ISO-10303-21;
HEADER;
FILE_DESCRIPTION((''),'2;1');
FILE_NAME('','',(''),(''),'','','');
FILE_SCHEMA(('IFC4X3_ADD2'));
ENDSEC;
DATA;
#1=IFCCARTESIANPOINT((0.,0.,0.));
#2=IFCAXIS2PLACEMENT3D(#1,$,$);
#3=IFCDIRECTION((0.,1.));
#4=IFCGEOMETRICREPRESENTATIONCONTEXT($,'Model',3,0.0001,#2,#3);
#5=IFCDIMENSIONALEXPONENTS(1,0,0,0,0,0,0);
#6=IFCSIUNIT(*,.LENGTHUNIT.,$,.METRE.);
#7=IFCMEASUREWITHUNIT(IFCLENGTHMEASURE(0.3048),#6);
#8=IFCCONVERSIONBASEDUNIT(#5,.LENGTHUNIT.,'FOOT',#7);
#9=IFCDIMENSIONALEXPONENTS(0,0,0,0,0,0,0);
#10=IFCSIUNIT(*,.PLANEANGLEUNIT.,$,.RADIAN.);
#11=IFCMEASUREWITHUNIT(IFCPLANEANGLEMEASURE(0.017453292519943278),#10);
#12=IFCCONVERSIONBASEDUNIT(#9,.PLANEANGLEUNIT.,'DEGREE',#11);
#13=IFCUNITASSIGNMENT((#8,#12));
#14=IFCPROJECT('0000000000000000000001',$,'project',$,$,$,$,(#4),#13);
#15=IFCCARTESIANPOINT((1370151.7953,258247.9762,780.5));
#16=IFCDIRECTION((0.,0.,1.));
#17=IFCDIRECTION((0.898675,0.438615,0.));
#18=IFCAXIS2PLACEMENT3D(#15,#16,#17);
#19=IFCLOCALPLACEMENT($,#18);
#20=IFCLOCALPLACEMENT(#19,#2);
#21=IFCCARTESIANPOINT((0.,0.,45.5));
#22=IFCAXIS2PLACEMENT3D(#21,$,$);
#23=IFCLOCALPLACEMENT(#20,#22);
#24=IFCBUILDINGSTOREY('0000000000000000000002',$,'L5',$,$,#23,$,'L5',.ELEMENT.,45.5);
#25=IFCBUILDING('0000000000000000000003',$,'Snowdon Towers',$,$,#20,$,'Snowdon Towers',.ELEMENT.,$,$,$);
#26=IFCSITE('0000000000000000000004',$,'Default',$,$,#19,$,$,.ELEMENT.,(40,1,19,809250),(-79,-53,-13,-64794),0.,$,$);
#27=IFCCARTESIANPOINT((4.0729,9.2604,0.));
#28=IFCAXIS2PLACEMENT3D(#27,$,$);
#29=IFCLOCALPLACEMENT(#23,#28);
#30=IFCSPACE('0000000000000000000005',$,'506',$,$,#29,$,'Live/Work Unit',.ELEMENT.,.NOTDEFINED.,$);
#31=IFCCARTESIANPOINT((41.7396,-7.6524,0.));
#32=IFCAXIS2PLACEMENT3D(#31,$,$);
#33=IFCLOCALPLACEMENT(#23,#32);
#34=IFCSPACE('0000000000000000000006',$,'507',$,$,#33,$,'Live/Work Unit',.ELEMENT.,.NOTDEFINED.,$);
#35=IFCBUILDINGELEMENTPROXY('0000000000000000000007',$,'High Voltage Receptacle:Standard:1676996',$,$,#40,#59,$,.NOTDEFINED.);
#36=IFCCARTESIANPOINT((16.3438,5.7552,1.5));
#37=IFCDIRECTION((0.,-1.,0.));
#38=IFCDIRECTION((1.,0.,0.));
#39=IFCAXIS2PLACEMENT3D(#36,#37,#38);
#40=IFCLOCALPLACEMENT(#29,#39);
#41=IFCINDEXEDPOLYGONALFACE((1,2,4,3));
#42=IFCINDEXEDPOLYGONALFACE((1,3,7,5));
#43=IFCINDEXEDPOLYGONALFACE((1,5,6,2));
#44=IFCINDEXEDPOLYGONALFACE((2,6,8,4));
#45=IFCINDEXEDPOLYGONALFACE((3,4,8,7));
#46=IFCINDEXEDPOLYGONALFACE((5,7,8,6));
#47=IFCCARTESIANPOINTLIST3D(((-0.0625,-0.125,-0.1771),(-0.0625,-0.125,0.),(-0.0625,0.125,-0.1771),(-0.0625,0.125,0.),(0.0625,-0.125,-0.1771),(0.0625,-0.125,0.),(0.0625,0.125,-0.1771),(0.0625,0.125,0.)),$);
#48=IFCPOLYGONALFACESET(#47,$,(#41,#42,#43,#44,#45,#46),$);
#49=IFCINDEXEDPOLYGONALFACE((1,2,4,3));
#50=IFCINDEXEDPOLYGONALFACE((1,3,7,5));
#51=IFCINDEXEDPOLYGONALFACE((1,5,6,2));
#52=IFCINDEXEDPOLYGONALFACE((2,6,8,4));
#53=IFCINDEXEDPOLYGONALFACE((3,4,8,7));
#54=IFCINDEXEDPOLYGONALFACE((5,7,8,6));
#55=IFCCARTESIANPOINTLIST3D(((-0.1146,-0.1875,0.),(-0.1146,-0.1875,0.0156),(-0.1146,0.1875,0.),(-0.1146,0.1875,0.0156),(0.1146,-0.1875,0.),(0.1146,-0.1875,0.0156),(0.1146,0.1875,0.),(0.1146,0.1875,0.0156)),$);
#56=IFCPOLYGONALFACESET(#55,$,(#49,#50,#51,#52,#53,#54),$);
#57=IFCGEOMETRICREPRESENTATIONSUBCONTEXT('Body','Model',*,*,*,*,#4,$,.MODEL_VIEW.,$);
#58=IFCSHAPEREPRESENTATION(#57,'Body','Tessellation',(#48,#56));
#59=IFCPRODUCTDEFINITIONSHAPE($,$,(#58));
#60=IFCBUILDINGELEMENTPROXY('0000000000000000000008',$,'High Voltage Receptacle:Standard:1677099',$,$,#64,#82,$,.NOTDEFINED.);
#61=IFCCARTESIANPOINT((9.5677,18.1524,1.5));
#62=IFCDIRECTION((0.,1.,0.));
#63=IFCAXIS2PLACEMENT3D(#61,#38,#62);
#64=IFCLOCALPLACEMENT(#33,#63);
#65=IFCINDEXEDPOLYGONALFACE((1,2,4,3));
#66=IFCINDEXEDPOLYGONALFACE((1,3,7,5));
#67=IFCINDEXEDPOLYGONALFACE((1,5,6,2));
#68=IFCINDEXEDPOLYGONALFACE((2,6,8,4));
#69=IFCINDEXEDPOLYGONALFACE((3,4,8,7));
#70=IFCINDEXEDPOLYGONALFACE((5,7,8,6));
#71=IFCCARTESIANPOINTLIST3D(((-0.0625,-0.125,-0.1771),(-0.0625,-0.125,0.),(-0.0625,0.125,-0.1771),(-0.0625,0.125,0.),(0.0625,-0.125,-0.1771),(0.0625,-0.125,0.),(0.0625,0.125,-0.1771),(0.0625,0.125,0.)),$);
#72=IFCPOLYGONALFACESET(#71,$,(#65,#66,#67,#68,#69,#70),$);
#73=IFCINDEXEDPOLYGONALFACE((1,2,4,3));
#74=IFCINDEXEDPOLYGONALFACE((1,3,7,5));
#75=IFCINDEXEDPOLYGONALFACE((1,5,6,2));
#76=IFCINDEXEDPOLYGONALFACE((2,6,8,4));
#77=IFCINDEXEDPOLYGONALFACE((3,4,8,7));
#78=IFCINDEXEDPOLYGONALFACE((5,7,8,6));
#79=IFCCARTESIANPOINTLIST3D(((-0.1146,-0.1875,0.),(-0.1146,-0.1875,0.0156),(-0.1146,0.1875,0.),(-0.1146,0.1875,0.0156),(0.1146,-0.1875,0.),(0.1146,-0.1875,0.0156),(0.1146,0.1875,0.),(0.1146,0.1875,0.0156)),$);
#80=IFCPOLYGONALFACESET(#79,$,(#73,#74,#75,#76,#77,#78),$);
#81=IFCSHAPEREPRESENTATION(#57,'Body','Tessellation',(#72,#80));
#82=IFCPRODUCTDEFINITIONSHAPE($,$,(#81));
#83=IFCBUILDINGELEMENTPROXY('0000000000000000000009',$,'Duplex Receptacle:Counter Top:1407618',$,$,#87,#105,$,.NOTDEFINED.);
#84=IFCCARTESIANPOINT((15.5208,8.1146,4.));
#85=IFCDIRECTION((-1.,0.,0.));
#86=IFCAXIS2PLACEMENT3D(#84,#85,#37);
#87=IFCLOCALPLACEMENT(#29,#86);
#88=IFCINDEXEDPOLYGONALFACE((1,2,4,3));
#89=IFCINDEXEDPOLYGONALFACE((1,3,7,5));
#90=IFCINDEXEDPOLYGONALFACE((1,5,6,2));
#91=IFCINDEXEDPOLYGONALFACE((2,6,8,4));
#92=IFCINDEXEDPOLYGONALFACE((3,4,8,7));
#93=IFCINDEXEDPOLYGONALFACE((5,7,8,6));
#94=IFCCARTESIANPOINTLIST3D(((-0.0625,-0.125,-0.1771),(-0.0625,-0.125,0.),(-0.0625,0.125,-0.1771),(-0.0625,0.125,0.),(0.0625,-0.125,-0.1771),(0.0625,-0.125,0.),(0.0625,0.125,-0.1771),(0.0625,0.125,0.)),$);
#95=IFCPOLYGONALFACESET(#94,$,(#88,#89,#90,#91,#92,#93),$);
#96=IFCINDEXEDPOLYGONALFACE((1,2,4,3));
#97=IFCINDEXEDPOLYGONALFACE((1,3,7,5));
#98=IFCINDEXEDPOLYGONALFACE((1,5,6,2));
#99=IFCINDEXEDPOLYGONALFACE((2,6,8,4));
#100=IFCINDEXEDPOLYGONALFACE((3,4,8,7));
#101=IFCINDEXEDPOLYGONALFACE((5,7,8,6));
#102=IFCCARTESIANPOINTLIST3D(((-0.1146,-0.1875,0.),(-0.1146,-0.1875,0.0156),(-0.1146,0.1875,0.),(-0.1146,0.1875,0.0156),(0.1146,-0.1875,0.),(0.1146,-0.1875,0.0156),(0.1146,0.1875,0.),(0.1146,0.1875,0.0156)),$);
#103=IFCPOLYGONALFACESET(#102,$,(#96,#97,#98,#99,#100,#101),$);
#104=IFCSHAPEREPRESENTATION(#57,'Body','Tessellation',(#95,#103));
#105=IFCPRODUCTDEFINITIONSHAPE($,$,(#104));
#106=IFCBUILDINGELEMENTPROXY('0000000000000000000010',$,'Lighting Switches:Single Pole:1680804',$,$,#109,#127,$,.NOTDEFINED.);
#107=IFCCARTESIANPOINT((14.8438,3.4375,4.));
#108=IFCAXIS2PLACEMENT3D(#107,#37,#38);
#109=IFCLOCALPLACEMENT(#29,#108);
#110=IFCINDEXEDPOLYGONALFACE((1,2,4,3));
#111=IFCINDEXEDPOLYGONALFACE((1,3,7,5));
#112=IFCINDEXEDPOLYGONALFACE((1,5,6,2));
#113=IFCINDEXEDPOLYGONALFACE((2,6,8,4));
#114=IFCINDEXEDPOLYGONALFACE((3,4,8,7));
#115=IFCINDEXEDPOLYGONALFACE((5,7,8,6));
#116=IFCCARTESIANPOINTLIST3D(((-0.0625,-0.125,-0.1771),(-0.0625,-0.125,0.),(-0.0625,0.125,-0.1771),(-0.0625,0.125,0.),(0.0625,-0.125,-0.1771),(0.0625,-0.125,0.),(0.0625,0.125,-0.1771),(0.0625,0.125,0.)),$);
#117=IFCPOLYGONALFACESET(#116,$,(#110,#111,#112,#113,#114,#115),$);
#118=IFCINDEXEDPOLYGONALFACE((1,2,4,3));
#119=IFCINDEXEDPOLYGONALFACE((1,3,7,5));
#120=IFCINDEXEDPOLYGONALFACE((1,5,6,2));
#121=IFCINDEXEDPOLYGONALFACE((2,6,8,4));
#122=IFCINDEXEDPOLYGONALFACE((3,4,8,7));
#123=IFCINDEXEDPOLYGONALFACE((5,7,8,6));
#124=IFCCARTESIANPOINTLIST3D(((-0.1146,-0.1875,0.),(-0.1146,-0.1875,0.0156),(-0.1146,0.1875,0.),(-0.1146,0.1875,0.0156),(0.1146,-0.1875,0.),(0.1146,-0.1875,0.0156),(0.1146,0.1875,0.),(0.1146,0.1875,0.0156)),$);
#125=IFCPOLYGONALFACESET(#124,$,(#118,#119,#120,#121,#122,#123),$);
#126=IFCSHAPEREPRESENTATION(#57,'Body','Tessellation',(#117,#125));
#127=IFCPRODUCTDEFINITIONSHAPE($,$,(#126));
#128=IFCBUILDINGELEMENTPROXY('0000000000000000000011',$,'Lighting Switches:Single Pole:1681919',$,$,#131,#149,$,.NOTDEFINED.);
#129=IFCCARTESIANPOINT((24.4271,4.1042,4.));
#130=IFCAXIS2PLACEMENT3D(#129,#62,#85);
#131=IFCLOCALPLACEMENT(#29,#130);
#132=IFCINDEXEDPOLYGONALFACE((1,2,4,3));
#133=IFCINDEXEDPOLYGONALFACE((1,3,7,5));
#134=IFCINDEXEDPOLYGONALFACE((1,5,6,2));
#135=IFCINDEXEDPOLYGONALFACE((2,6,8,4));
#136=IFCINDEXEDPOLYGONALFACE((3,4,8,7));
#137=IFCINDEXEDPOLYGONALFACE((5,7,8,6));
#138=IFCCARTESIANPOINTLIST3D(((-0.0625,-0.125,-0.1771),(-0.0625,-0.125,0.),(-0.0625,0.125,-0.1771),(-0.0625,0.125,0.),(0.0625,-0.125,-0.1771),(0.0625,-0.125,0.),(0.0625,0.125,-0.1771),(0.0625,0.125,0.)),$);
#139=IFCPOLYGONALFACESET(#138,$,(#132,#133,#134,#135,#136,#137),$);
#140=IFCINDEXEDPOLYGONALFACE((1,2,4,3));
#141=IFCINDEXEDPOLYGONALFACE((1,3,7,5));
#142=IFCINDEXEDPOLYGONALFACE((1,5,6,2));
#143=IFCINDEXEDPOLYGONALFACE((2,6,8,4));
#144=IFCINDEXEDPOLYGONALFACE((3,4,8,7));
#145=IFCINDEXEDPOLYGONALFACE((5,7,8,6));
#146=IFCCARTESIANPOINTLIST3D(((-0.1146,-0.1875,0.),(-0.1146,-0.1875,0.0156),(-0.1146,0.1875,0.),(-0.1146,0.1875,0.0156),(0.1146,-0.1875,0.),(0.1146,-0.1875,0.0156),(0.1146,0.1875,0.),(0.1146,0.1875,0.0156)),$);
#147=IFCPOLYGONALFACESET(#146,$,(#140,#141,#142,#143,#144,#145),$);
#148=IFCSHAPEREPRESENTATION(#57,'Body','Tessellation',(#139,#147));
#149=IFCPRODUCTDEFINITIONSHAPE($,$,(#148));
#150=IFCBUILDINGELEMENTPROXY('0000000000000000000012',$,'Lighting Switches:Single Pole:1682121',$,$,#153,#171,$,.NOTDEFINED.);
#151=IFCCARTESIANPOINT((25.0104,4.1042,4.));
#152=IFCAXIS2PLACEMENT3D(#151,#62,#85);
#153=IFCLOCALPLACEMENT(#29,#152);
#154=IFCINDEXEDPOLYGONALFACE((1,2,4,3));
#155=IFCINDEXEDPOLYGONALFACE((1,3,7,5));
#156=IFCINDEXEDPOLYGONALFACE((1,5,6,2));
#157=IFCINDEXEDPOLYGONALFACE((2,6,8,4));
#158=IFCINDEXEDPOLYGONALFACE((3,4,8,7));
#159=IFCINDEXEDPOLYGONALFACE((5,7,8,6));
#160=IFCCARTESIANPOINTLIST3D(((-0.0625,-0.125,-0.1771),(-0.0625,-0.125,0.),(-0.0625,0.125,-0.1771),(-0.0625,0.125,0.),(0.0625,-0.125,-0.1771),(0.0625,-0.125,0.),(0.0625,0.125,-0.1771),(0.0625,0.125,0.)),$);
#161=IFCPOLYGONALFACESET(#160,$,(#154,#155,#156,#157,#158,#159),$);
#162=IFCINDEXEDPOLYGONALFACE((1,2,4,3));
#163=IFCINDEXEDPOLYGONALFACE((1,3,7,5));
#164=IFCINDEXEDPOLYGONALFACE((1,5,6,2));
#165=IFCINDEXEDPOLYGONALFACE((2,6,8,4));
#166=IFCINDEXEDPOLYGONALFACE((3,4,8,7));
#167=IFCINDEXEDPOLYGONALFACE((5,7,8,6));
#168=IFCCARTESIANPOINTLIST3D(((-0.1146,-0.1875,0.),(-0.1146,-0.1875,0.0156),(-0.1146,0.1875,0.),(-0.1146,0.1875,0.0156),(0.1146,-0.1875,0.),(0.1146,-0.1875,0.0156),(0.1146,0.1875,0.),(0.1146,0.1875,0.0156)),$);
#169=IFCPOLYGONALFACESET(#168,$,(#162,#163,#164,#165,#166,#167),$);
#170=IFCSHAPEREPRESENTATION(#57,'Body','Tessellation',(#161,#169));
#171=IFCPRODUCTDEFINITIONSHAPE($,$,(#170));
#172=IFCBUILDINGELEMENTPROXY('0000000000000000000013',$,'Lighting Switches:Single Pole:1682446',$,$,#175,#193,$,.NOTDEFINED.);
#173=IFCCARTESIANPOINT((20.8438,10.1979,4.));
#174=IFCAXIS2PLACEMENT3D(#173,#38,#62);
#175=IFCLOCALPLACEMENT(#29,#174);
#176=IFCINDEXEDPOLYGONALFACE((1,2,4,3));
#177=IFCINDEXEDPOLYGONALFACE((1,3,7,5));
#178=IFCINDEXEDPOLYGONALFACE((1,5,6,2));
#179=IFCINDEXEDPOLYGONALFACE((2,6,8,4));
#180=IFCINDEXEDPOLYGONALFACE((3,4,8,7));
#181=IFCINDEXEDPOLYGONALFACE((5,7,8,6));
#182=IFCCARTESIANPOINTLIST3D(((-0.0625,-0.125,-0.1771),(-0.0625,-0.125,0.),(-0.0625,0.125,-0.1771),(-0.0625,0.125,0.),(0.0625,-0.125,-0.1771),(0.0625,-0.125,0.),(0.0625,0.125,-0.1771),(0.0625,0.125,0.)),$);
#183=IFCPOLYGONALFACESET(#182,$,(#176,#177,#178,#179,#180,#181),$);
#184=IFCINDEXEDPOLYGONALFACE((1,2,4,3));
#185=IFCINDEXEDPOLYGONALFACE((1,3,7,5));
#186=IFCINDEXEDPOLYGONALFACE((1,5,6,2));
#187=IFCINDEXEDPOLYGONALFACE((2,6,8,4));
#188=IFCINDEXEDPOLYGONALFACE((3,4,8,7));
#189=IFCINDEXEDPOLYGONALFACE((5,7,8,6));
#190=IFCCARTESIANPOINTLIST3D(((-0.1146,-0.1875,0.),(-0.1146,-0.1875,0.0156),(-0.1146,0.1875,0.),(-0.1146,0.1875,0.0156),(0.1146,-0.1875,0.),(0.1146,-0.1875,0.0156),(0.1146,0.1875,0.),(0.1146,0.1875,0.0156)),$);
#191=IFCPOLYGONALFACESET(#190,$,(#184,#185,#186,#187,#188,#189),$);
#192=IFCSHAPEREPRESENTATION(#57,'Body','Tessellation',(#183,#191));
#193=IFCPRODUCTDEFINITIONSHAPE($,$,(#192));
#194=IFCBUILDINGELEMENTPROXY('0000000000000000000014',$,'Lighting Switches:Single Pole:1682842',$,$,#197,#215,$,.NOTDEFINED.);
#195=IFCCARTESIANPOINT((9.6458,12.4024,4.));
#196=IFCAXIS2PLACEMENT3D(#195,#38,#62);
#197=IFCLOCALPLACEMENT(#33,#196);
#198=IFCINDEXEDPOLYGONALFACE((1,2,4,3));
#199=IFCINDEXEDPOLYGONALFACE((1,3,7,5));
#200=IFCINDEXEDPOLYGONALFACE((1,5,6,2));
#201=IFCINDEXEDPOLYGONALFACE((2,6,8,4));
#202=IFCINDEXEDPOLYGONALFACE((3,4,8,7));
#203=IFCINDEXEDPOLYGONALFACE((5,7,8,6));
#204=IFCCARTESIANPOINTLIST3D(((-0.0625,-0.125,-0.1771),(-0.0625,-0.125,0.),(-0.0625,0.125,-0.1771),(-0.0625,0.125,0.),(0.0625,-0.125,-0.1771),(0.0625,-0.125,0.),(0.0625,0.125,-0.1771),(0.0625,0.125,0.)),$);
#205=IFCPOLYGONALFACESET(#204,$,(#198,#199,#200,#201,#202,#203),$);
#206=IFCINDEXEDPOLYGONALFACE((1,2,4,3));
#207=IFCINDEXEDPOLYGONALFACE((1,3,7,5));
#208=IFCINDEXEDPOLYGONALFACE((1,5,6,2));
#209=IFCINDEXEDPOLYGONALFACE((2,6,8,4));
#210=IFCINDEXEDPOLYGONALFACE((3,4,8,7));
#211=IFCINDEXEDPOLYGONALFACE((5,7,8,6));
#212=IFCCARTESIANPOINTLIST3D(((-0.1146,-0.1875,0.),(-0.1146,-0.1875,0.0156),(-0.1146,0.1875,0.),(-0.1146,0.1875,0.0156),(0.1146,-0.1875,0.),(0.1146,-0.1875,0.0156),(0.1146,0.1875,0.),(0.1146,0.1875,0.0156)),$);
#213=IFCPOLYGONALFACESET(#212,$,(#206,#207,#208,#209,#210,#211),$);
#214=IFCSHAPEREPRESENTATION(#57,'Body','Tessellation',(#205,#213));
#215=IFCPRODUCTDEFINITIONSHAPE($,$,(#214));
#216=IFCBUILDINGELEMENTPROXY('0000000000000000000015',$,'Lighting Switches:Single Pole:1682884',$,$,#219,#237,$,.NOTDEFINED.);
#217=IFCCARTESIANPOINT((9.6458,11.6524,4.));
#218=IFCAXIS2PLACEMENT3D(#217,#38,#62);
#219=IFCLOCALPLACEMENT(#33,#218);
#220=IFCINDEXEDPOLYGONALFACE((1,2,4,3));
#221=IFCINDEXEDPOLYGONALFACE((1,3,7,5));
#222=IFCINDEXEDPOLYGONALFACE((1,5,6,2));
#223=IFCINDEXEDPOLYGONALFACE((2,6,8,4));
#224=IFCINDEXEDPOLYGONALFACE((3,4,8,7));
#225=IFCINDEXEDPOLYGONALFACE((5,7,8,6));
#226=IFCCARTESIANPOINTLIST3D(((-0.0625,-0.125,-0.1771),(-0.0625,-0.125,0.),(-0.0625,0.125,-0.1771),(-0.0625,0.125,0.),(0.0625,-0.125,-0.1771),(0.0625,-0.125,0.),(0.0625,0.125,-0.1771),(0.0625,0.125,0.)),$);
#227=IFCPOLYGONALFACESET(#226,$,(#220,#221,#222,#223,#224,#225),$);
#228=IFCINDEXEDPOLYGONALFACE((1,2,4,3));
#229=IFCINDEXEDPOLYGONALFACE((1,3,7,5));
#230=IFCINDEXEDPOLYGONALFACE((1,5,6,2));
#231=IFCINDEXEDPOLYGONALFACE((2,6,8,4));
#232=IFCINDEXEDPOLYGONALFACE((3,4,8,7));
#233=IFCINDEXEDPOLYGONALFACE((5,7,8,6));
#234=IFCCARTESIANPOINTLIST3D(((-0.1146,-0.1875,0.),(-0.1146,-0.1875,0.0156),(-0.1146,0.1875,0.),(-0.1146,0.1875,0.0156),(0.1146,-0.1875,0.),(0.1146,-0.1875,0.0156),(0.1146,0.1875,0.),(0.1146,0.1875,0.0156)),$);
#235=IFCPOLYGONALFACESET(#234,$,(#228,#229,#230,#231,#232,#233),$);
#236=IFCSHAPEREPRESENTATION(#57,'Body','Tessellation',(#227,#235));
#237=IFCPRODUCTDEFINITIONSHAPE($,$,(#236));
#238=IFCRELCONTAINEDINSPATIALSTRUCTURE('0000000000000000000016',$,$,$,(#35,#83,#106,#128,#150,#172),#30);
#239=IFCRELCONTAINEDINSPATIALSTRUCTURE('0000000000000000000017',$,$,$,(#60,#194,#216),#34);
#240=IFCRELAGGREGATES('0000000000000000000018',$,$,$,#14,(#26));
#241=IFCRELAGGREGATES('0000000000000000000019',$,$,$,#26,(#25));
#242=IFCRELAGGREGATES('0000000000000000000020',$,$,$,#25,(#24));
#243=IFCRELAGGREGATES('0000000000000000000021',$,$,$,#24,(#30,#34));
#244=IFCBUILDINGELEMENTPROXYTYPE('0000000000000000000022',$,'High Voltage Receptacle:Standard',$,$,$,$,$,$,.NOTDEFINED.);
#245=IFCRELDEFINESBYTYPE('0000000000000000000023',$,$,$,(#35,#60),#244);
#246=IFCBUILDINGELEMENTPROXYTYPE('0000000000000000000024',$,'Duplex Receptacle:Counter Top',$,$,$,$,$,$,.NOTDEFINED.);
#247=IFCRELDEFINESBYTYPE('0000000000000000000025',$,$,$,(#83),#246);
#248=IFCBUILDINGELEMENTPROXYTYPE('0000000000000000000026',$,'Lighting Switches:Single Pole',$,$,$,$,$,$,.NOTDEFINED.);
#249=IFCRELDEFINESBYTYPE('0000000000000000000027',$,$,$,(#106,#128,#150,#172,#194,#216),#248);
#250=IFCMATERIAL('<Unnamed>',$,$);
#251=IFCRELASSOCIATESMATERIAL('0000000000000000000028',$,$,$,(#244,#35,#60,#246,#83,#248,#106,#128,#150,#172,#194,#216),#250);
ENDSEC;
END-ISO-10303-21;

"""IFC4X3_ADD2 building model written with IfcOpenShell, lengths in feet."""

from ifc_helpers import new_model, entity, si_unit, converted_unit, direction, frame, frame_2d, origin, origin_2d_with_axis, place, context, subcontext, project, spatial, rectangle, extrude, source, transform, mapped, material, type_object, type_shapes, element, save


model = new_model("IFC4X3_ADD2")

# Units and contexts
model_context = context("Model", 3, precision=0.0001, world=origin(), true_north=direction((0.0, 1.0)))
body_context = subcontext(model_context, "Body", "Model", "MODEL_VIEW")
ifc_project = project(units=[converted_unit("LENGTHUNIT", "FOOT", entity("IfcLengthMeasure", 0.3048), si_unit("LENGTHUNIT", "METRE"), dimensions=[1, 0, 0, 0, 0, 0, 0]), converted_unit("PLANEANGLEUNIT", "DEGREE", entity("IfcPlaneAngleMeasure", 0.017453292519943278), si_unit("PLANEANGLEUNIT", "RADIAN"), dimensions=[0, 0, 0, 0, 0, 0, 0])], contexts=[model_context])

# Site, building, storey, space
site_placement = place(None, frame((1370151.7953, 258247.9762, 780.5), z_axis=(0.0, 0.0, 1.0), x_axis=(0.898675, 0.438615, 0.0)))
site = spatial("IfcSite", under=ifc_project, at=site_placement, Name="Default", CompositionType="ELEMENT", RefLatitude=(40, 1, 19, 809250), RefLongitude=(-79, -53, -13, -64794), RefElevation=0.0)
building_placement = place(site_placement, origin())
building = spatial("IfcBuilding", under=site, at=building_placement, Name="Snowdon Towers", LongName="Snowdon Towers", CompositionType="ELEMENT")
storey_placement = place(building_placement, frame((0.0, 0.0, 45.5)))
storey = spatial("IfcBuildingStorey", under=building, at=storey_placement, Name="L5", LongName="L5", CompositionType="ELEMENT", Elevation=45.5)
space_1_placement = place(storey_placement, frame((4.0729, 9.2604, 0.0)))
space_1 = spatial("IfcSpace", under=storey, at=space_1_placement, Name="506", LongName="Live/Work Unit", CompositionType="ELEMENT", PredefinedType="NOTDEFINED")

# Shared definitions
ifc_material_1 = material(Name="<Unnamed>")

# Shared definitions
space_2_placement = place(storey_placement, frame((41.7396, -7.6524, 0.0)))
space_2 = spatial("IfcSpace", under=storey, at=space_2_placement, Name="507", LongName="Live/Work Unit", CompositionType="ELEMENT", PredefinedType="NOTDEFINED")

# Building element proxies
building_element_proxy_type_1 = type_object("IfcBuildingElementProxyType", Name="High Voltage Receptacle:Standard", PredefinedType="NOTDEFINED", material=ifc_material_1)
shared_shape_1 = source(origin(), body_context, "Body", "SweptSolid", [
    extrude(rectangle(XDim=0.125, YDim=0.25, at=origin_2d_with_axis()), frame((0.0, 0.0, -0.1771), z_axis=(0.0, 0.0, 1.0), x_axis=(-1.0, 0.0, 0.0)), (0.0, 0.0, 1.0), 0.1771),
    extrude(rectangle(XDim=0.2292, YDim=0.375, at=frame_2d((0.0, 0.0), x_axis=(1.0, 0.0))), frame((0.0, 0.0, 0.0), z_axis=(0.0, 0.0, 1.0), x_axis=(-1.0, 0.0, 0.0)), (0.0, 0.0, 1.0), 0.0156),
])
type_shapes(building_element_proxy_type_1, [shared_shape_1])
proxy_1_placement = place(space_1_placement, frame((16.3438, 5.7552, 1.5), z_axis=(0.0, -1.0, 0.0), x_axis=(1.0, 0.0, 0.0)))
element("IfcBuildingElementProxy", 1, at=proxy_1_placement, inside=space_1, type_object=building_element_proxy_type_1, material=ifc_material_1, Name="High Voltage Receptacle:Standard:1676996", PredefinedType="NOTDEFINED", context=body_context, shape_type="MappedRepresentation", body=[
    mapped(shared_shape_1, transform((0.0, 0.0, 0.0), scale=1.0)),
])
proxy_2_placement = place(space_2_placement, frame((9.5677, 18.1524, 1.5), z_axis=(1.0, 0.0, 0.0), x_axis=(0.0, 1.0, 0.0)))
element("IfcBuildingElementProxy", 2, at=proxy_2_placement, inside=space_2, type_object=building_element_proxy_type_1, material=ifc_material_1, Name="High Voltage Receptacle:Standard:1677099", PredefinedType="NOTDEFINED", context=body_context, shape_type="MappedRepresentation", body=[
    mapped(shared_shape_1, transform((0.0, 0.0, 0.0), scale=1.0)),
])
building_element_proxy_type_2 = type_object("IfcBuildingElementProxyType", Name="Duplex Receptacle:Counter Top", PredefinedType="NOTDEFINED", material=ifc_material_1)
shared_shape_2 = source(origin(), body_context, "Body", "SweptSolid", [
    extrude(rectangle(XDim=0.125, YDim=0.25, at=origin_2d_with_axis()), frame((0.0, 0.0, -0.1771), z_axis=(0.0, 0.0, 1.0), x_axis=(-1.0, 0.0, 0.0)), (0.0, 0.0, 1.0), 0.1771),
    extrude(rectangle(XDim=0.2292, YDim=0.375, at=frame_2d((0.0, 0.0), x_axis=(1.0, 0.0))), frame((0.0, 0.0, 0.0), z_axis=(0.0, 0.0, 1.0), x_axis=(-1.0, 0.0, 0.0)), (0.0, 0.0, 1.0), 0.0156),
])
type_shapes(building_element_proxy_type_2, [shared_shape_2])
proxy_3_placement = place(space_1_placement, frame((15.5208, 8.1146, 4.0), z_axis=(-1.0, 0.0, 0.0), x_axis=(0.0, -1.0, 0.0)))
element("IfcBuildingElementProxy", 3, at=proxy_3_placement, inside=space_1, type_object=building_element_proxy_type_2, material=ifc_material_1, Name="Duplex Receptacle:Counter Top:1407618", PredefinedType="NOTDEFINED", context=body_context, shape_type="MappedRepresentation", body=[
    mapped(shared_shape_2, transform((0.0, 0.0, 0.0), scale=1.0)),
])
building_element_proxy_type_3 = type_object("IfcBuildingElementProxyType", Name="Lighting Switches:Single Pole", PredefinedType="NOTDEFINED", material=ifc_material_1)
shared_shape_3 = source(origin(), body_context, "Body", "SweptSolid", [
    extrude(rectangle(XDim=0.125, YDim=0.25, at=origin_2d_with_axis()), frame((0.0, 0.0, -0.1771), z_axis=(0.0, 0.0, 1.0), x_axis=(-1.0, 0.0, 0.0)), (0.0, 0.0, 1.0), 0.1771),
    extrude(rectangle(XDim=0.2292, YDim=0.375, at=frame_2d((0.0, 0.0), x_axis=(1.0, 0.0))), frame((0.0, 0.0, 0.0), z_axis=(0.0, 0.0, 1.0), x_axis=(-1.0, 0.0, 0.0)), (0.0, 0.0, 1.0), 0.0156),
])
type_shapes(building_element_proxy_type_3, [shared_shape_3])
for number, where, z_axis, x_axis, name in (
    (4, (14.8438, 3.4375, 4.0), (0.0, -1.0, 0.0), (1.0, 0.0, 0.0), "Lighting Switches:Single Pole:1680804"),
    (5, (24.4271, 4.1042, 4.0), (0.0, 1.0, 0.0), (-1.0, 0.0, 0.0), "Lighting Switches:Single Pole:1681919"),
    (6, (25.0104, 4.1042, 4.0), (0.0, 1.0, 0.0), (-1.0, 0.0, 0.0), "Lighting Switches:Single Pole:1682121"),
    (7, (20.8438, 10.1979, 4.0), (1.0, 0.0, 0.0), (0.0, 1.0, 0.0), "Lighting Switches:Single Pole:1682446"),
):
    element("IfcBuildingElementProxy", number, at=place(space_1_placement, frame(where, z_axis=z_axis, x_axis=x_axis)), inside=space_1, type_object=building_element_proxy_type_3, material=ifc_material_1, Name=name, PredefinedType="NOTDEFINED", context=body_context, shape_type="MappedRepresentation", body=[
        mapped(shared_shape_3, transform((0.0, 0.0, 0.0), scale=1.0)),
    ])
for number, where, z_axis, x_axis, name in (
    (8, (9.6458, 12.4024, 4.0), (1.0, 0.0, 0.0), (0.0, 1.0, 0.0), "Lighting Switches:Single Pole:1682842"),
    (9, (9.6458, 11.6524, 4.0), (1.0, 0.0, 0.0), (0.0, 1.0, 0.0), "Lighting Switches:Single Pole:1682884"),
):
    element("IfcBuildingElementProxy", number, at=place(space_2_placement, frame(where, z_axis=z_axis, x_axis=x_axis)), inside=space_2, type_object=building_element_proxy_type_3, material=ifc_material_1, Name=name, PredefinedType="NOTDEFINED", context=body_context, shape_type="MappedRepresentation", body=[
        mapped(shared_shape_3, transform((0.0, 0.0, 0.0), scale=1.0)),
    ])

save(model, "model.ifc")
